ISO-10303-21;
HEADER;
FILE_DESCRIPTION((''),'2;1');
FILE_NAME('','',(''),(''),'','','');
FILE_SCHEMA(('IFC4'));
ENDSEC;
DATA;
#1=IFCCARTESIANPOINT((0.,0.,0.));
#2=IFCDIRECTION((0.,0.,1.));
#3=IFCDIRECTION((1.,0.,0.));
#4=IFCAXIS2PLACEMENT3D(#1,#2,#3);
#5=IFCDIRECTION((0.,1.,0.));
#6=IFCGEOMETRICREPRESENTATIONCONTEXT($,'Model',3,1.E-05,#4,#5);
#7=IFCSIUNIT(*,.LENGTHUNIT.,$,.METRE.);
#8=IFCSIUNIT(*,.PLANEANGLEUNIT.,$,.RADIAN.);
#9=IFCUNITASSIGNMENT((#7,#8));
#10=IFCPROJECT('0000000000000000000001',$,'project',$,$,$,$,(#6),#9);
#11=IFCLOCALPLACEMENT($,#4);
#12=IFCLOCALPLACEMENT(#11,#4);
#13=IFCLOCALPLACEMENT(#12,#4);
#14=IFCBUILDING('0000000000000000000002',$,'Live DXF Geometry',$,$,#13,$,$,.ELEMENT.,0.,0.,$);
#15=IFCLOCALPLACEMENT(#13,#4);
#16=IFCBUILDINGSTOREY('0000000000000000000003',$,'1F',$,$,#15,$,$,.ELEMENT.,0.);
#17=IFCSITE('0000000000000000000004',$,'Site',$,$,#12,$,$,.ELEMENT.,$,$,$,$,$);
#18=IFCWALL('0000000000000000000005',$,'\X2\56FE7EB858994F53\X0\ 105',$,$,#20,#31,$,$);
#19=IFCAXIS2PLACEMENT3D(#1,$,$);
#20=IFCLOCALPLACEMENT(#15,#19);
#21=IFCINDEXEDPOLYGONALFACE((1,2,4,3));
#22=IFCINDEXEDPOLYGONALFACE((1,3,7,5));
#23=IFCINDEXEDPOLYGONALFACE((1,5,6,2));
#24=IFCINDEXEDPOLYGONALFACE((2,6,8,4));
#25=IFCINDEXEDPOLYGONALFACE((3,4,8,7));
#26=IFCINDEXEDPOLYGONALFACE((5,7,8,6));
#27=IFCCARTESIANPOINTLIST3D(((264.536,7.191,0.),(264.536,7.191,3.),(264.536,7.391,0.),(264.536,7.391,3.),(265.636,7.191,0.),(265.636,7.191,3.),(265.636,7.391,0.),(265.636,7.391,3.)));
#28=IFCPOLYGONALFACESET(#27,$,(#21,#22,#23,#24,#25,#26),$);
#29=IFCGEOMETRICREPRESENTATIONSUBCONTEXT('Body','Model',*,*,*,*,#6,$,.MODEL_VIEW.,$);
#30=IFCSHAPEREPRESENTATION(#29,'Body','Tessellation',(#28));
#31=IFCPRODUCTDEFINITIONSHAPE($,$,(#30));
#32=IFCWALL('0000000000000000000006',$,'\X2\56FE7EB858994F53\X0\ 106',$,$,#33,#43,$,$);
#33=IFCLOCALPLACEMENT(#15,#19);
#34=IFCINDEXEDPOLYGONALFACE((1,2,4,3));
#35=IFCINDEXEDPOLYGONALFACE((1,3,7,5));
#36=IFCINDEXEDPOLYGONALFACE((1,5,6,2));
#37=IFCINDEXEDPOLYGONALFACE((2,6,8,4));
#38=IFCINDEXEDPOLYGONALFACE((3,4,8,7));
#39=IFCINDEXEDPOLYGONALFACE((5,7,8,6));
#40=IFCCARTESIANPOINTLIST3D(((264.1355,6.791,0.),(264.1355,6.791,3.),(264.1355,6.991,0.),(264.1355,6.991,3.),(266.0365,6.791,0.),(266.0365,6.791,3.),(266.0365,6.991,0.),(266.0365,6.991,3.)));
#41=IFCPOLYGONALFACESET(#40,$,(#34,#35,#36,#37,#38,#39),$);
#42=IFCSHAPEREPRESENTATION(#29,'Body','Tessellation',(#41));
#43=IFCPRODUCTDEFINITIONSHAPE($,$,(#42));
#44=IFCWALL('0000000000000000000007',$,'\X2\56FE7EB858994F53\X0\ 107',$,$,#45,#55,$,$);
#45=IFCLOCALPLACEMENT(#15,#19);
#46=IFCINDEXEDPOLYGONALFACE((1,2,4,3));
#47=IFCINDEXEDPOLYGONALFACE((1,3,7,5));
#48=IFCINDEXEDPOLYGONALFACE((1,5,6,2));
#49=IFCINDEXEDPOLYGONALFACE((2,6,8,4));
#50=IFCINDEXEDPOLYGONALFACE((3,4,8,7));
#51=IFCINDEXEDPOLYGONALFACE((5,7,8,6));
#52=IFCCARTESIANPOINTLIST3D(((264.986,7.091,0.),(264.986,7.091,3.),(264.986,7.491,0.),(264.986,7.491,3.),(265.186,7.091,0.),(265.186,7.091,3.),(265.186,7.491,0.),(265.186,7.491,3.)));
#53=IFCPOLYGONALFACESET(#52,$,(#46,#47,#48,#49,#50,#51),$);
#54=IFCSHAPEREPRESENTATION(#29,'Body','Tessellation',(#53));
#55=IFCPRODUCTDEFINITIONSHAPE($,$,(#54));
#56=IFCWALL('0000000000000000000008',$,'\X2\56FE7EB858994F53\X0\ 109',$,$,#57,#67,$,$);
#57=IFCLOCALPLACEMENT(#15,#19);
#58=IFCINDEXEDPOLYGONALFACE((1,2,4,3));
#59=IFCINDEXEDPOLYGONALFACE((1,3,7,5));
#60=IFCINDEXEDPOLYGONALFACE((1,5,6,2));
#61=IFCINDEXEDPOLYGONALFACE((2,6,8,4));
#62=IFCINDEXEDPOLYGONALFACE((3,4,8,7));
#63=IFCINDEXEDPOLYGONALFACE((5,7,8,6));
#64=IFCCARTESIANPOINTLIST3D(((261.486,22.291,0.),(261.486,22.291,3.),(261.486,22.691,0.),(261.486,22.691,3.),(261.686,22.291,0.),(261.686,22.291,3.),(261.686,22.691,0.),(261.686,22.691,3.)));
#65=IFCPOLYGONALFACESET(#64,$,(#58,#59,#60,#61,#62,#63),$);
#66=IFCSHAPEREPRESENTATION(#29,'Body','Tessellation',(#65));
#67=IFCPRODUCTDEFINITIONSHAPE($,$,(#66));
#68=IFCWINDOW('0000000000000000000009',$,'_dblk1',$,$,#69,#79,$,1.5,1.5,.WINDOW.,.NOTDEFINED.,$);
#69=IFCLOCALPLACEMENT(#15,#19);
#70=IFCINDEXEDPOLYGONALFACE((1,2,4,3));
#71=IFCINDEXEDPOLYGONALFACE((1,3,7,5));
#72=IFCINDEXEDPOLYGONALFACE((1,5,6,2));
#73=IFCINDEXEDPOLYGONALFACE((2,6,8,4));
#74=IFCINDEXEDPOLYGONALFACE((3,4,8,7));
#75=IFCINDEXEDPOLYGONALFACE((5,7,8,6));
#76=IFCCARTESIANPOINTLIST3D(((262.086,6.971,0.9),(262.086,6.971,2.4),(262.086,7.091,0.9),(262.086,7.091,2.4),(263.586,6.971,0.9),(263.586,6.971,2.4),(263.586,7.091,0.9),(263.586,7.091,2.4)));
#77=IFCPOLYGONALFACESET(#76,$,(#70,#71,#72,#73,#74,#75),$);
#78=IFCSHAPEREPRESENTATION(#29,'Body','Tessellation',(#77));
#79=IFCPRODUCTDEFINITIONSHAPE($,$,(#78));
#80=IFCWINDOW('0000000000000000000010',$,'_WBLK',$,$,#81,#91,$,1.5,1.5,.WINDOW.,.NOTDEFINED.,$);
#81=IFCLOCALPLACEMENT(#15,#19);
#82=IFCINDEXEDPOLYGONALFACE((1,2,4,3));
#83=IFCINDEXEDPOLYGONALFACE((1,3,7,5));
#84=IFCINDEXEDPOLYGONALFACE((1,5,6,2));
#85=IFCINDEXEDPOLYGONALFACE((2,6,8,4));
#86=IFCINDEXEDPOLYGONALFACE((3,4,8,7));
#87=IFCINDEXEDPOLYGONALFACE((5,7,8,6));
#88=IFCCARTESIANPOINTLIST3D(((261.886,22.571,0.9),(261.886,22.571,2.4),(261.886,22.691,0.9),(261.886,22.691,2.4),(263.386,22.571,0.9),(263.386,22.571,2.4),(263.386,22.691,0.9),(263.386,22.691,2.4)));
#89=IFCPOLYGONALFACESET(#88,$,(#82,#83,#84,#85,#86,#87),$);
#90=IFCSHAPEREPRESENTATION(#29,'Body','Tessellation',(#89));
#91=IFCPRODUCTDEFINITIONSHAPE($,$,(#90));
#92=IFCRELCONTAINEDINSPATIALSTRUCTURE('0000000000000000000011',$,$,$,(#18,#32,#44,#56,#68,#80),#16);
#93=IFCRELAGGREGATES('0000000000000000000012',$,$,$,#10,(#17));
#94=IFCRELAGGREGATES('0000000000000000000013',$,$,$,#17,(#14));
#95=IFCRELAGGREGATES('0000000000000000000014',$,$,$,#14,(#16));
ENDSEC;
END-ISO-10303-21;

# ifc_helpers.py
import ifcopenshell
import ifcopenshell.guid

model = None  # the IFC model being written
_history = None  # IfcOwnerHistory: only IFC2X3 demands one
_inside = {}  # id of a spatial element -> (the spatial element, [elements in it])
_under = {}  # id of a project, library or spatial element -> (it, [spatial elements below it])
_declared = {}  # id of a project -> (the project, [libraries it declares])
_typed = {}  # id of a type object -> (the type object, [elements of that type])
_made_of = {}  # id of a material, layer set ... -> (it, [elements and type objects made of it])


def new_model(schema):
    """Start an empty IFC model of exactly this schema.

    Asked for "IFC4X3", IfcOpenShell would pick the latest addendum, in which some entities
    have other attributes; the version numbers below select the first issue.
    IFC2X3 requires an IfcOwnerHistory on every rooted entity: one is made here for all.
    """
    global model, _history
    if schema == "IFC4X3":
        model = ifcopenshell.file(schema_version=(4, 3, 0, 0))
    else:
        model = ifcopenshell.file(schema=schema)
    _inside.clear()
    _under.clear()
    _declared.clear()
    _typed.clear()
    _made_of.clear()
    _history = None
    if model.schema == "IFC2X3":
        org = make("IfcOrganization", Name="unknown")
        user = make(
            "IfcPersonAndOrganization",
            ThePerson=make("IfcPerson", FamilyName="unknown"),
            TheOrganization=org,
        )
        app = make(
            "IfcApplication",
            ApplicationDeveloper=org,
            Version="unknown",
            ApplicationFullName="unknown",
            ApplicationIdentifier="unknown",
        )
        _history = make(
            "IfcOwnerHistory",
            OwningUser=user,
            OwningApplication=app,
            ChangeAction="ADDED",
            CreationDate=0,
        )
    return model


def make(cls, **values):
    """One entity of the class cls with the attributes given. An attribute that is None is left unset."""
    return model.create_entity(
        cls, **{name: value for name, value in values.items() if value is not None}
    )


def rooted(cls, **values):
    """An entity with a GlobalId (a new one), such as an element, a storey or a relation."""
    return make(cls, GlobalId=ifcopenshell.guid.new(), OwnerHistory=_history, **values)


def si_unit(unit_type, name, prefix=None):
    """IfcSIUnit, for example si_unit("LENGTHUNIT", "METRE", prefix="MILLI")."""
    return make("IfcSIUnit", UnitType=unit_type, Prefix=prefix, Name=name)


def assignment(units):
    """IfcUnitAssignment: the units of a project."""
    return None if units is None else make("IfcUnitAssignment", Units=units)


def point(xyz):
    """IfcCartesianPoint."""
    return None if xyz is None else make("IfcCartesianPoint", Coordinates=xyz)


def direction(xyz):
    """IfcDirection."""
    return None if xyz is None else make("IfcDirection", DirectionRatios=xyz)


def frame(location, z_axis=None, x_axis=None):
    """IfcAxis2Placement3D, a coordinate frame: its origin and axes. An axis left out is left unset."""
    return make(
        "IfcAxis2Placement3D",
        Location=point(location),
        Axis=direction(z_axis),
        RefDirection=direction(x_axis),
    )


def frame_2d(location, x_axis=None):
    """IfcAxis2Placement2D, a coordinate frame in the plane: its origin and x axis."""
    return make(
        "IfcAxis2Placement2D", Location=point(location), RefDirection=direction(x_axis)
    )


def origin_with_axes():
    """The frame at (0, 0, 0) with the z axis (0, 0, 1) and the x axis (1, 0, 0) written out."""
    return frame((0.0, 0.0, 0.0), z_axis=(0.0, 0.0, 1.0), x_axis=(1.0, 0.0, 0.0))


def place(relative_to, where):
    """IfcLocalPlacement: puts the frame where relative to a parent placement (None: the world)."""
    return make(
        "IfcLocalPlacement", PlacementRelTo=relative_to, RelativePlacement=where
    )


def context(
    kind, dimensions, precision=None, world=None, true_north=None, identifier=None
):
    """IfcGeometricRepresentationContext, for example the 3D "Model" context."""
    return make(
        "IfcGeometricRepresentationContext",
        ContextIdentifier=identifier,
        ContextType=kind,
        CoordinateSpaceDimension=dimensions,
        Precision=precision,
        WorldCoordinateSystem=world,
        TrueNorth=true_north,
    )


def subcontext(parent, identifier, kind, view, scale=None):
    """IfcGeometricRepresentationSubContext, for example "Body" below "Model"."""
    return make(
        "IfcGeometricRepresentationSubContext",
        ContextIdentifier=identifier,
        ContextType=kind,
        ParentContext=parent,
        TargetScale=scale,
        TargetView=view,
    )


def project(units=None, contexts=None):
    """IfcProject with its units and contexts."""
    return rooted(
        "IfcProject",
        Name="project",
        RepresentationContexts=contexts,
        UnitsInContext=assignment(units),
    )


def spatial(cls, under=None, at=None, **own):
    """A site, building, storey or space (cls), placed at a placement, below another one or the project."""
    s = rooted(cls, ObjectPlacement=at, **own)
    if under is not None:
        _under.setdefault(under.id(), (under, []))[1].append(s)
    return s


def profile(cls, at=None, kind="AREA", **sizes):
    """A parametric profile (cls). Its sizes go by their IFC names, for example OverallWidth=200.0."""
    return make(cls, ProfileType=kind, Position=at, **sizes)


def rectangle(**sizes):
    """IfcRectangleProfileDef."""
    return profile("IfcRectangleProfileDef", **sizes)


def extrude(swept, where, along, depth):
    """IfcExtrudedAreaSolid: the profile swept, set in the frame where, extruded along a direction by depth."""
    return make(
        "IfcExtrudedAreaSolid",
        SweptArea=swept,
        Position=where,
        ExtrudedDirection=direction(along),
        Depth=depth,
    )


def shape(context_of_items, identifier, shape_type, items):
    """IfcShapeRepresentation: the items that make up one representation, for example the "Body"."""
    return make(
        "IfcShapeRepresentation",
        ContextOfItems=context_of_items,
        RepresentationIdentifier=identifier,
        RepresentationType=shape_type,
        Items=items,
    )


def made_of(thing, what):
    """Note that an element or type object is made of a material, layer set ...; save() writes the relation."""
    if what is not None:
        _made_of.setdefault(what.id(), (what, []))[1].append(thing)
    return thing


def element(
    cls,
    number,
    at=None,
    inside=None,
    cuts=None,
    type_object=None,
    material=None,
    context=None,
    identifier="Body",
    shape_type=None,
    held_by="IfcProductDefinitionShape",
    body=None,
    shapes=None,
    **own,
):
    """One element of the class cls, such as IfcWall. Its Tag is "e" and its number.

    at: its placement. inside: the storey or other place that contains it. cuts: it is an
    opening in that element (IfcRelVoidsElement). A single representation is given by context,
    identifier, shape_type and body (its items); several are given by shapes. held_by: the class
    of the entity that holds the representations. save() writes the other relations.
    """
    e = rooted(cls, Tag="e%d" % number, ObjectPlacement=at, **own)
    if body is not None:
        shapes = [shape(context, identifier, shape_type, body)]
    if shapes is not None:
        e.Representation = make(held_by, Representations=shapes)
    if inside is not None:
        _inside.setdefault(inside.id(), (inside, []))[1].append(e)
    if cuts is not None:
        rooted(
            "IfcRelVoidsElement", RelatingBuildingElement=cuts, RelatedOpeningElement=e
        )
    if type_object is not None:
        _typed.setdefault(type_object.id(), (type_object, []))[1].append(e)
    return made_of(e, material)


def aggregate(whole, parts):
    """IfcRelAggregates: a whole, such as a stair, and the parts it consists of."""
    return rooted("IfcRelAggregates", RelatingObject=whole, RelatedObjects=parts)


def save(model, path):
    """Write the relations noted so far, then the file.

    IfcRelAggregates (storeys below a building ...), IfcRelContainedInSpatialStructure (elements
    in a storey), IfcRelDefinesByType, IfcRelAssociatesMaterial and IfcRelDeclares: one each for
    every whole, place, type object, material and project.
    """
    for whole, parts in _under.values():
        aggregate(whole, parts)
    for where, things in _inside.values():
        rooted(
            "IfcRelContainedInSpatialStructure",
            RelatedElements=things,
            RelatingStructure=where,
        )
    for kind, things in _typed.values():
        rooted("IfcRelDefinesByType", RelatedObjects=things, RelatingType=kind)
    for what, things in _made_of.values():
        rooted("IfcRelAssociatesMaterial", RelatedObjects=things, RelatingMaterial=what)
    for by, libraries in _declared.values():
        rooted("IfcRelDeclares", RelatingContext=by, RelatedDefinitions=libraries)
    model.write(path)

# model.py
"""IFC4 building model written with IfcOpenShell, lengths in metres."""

from ifc_helpers import new_model, si_unit, direction, frame, frame_2d, origin_with_axes, place, context, subcontext, project, spatial, rectangle, extrude, element, save


model = new_model("IFC4")

# Units and contexts
model_context = context("Model", 3, precision=1e-05, world=origin_with_axes(), true_north=direction((0.0, 1.0, 0.0)))
body_context = subcontext(model_context, "Body", "Model", "MODEL_VIEW")
ifc_project = project(units=[si_unit("LENGTHUNIT", "METRE"), si_unit("PLANEANGLEUNIT", "RADIAN")], contexts=[model_context])

# Site, building, storey
placement = place(None, origin_with_axes())
site_placement = place(placement, origin_with_axes())
site = spatial("IfcSite", under=ifc_project, at=site_placement, Name="Site", CompositionType="ELEMENT")
building_placement = place(site_placement, origin_with_axes())
building = spatial("IfcBuilding", under=site, at=building_placement, Name="Live DXF Geometry", CompositionType="ELEMENT", ElevationOfRefHeight=0.0, ElevationOfTerrain=0.0)
storey_placement = place(building_placement, origin_with_axes())
storey = spatial("IfcBuildingStorey", under=building, at=storey_placement, Name="1F", CompositionType="ELEMENT", Elevation=0.0)

# Walls
wall_1_placement = place(storey_placement, frame((265.086, 7.291, 0.0), z_axis=(0.0, 0.0, 1.0), x_axis=(1.0, 0.0, 0.0)))
element("IfcWall", 1, at=wall_1_placement, inside=storey, Name="图纸墙体 105", context=body_context, shape_type="SweptSolid", body=[
    extrude(rectangle(XDim=1.1, YDim=0.2, at=frame_2d((0.0, 0.0), x_axis=(1.0, 0.0, 0.0))), frame((0.0, 0.0, 0.0), z_axis=(0.0, 0.0, 1.0)), (0.0, 0.0, 1.0), 3.0),
])
wall_2_placement = place(storey_placement, frame((265.086, 6.891, 0.0), z_axis=(0.0, 0.0, 1.0), x_axis=(1.0, 0.0, 0.0)))
element("IfcWall", 2, at=wall_2_placement, inside=storey, Name="图纸墙体 106", context=body_context, shape_type="SweptSolid", body=[
    extrude(rectangle(XDim=1.901, YDim=0.2, at=frame_2d((0.0, 0.0), x_axis=(1.0, 0.0, 0.0))), frame((0.0, 0.0, 0.0), z_axis=(0.0, 0.0, 1.0)), (0.0, 0.0, 1.0), 3.0),
])
for number, where, z_axis, x_axis, name in (
    (3, (265.086, 7.291, 0.0), (0.0, 0.0, 1.0), (0.0, -1.0, 0.0), "图纸墙体 107"),
    (4, (261.586, 22.491, 0.0), (0.0, 0.0, 1.0), (0.0, 1.0, 0.0), "图纸墙体 109"),
):
    element("IfcWall", number, at=place(storey_placement, frame(where, z_axis=z_axis, x_axis=x_axis)), inside=storey, Name=name, context=body_context, shape_type="SweptSolid", body=[
        extrude(rectangle(XDim=0.4, YDim=0.2, at=frame_2d((0.0, 0.0), x_axis=(1.0, 0.0, 0.0))), frame((0.0, 0.0, 0.0), z_axis=(0.0, 0.0, 1.0)), (0.0, 0.0, 1.0), 3.0),
    ])

# Windows
for number, where, z_axis, x_axis, name in (
    (5, (262.836, 7.031, 0.9), (0.0, 0.0, 1.0), (1.0, 0.0, 0.0), "_dblk1"),
    (6, (262.636, 22.631, 0.9), (0.0, 0.0, 1.0), (1.0, 0.0, 0.0), "_WBLK"),
):
    element("IfcWindow", number, at=place(storey_placement, frame(where, z_axis=z_axis, x_axis=x_axis)), inside=storey, Name=name, OverallHeight=1.5, OverallWidth=1.5, PartitioningType="NOTDEFINED", PredefinedType="WINDOW", context=body_context, shape_type="SweptSolid", body=[
        extrude(rectangle(XDim=1.5, YDim=0.12, at=frame_2d((0.0, 0.0), x_axis=(1.0, 0.0, 0.0))), frame((0.0, 0.0, 0.0), z_axis=(0.0, 0.0, 1.0)), (0.0, 0.0, 1.0), 1.5),
    ])

save(model, "model.ifc")
